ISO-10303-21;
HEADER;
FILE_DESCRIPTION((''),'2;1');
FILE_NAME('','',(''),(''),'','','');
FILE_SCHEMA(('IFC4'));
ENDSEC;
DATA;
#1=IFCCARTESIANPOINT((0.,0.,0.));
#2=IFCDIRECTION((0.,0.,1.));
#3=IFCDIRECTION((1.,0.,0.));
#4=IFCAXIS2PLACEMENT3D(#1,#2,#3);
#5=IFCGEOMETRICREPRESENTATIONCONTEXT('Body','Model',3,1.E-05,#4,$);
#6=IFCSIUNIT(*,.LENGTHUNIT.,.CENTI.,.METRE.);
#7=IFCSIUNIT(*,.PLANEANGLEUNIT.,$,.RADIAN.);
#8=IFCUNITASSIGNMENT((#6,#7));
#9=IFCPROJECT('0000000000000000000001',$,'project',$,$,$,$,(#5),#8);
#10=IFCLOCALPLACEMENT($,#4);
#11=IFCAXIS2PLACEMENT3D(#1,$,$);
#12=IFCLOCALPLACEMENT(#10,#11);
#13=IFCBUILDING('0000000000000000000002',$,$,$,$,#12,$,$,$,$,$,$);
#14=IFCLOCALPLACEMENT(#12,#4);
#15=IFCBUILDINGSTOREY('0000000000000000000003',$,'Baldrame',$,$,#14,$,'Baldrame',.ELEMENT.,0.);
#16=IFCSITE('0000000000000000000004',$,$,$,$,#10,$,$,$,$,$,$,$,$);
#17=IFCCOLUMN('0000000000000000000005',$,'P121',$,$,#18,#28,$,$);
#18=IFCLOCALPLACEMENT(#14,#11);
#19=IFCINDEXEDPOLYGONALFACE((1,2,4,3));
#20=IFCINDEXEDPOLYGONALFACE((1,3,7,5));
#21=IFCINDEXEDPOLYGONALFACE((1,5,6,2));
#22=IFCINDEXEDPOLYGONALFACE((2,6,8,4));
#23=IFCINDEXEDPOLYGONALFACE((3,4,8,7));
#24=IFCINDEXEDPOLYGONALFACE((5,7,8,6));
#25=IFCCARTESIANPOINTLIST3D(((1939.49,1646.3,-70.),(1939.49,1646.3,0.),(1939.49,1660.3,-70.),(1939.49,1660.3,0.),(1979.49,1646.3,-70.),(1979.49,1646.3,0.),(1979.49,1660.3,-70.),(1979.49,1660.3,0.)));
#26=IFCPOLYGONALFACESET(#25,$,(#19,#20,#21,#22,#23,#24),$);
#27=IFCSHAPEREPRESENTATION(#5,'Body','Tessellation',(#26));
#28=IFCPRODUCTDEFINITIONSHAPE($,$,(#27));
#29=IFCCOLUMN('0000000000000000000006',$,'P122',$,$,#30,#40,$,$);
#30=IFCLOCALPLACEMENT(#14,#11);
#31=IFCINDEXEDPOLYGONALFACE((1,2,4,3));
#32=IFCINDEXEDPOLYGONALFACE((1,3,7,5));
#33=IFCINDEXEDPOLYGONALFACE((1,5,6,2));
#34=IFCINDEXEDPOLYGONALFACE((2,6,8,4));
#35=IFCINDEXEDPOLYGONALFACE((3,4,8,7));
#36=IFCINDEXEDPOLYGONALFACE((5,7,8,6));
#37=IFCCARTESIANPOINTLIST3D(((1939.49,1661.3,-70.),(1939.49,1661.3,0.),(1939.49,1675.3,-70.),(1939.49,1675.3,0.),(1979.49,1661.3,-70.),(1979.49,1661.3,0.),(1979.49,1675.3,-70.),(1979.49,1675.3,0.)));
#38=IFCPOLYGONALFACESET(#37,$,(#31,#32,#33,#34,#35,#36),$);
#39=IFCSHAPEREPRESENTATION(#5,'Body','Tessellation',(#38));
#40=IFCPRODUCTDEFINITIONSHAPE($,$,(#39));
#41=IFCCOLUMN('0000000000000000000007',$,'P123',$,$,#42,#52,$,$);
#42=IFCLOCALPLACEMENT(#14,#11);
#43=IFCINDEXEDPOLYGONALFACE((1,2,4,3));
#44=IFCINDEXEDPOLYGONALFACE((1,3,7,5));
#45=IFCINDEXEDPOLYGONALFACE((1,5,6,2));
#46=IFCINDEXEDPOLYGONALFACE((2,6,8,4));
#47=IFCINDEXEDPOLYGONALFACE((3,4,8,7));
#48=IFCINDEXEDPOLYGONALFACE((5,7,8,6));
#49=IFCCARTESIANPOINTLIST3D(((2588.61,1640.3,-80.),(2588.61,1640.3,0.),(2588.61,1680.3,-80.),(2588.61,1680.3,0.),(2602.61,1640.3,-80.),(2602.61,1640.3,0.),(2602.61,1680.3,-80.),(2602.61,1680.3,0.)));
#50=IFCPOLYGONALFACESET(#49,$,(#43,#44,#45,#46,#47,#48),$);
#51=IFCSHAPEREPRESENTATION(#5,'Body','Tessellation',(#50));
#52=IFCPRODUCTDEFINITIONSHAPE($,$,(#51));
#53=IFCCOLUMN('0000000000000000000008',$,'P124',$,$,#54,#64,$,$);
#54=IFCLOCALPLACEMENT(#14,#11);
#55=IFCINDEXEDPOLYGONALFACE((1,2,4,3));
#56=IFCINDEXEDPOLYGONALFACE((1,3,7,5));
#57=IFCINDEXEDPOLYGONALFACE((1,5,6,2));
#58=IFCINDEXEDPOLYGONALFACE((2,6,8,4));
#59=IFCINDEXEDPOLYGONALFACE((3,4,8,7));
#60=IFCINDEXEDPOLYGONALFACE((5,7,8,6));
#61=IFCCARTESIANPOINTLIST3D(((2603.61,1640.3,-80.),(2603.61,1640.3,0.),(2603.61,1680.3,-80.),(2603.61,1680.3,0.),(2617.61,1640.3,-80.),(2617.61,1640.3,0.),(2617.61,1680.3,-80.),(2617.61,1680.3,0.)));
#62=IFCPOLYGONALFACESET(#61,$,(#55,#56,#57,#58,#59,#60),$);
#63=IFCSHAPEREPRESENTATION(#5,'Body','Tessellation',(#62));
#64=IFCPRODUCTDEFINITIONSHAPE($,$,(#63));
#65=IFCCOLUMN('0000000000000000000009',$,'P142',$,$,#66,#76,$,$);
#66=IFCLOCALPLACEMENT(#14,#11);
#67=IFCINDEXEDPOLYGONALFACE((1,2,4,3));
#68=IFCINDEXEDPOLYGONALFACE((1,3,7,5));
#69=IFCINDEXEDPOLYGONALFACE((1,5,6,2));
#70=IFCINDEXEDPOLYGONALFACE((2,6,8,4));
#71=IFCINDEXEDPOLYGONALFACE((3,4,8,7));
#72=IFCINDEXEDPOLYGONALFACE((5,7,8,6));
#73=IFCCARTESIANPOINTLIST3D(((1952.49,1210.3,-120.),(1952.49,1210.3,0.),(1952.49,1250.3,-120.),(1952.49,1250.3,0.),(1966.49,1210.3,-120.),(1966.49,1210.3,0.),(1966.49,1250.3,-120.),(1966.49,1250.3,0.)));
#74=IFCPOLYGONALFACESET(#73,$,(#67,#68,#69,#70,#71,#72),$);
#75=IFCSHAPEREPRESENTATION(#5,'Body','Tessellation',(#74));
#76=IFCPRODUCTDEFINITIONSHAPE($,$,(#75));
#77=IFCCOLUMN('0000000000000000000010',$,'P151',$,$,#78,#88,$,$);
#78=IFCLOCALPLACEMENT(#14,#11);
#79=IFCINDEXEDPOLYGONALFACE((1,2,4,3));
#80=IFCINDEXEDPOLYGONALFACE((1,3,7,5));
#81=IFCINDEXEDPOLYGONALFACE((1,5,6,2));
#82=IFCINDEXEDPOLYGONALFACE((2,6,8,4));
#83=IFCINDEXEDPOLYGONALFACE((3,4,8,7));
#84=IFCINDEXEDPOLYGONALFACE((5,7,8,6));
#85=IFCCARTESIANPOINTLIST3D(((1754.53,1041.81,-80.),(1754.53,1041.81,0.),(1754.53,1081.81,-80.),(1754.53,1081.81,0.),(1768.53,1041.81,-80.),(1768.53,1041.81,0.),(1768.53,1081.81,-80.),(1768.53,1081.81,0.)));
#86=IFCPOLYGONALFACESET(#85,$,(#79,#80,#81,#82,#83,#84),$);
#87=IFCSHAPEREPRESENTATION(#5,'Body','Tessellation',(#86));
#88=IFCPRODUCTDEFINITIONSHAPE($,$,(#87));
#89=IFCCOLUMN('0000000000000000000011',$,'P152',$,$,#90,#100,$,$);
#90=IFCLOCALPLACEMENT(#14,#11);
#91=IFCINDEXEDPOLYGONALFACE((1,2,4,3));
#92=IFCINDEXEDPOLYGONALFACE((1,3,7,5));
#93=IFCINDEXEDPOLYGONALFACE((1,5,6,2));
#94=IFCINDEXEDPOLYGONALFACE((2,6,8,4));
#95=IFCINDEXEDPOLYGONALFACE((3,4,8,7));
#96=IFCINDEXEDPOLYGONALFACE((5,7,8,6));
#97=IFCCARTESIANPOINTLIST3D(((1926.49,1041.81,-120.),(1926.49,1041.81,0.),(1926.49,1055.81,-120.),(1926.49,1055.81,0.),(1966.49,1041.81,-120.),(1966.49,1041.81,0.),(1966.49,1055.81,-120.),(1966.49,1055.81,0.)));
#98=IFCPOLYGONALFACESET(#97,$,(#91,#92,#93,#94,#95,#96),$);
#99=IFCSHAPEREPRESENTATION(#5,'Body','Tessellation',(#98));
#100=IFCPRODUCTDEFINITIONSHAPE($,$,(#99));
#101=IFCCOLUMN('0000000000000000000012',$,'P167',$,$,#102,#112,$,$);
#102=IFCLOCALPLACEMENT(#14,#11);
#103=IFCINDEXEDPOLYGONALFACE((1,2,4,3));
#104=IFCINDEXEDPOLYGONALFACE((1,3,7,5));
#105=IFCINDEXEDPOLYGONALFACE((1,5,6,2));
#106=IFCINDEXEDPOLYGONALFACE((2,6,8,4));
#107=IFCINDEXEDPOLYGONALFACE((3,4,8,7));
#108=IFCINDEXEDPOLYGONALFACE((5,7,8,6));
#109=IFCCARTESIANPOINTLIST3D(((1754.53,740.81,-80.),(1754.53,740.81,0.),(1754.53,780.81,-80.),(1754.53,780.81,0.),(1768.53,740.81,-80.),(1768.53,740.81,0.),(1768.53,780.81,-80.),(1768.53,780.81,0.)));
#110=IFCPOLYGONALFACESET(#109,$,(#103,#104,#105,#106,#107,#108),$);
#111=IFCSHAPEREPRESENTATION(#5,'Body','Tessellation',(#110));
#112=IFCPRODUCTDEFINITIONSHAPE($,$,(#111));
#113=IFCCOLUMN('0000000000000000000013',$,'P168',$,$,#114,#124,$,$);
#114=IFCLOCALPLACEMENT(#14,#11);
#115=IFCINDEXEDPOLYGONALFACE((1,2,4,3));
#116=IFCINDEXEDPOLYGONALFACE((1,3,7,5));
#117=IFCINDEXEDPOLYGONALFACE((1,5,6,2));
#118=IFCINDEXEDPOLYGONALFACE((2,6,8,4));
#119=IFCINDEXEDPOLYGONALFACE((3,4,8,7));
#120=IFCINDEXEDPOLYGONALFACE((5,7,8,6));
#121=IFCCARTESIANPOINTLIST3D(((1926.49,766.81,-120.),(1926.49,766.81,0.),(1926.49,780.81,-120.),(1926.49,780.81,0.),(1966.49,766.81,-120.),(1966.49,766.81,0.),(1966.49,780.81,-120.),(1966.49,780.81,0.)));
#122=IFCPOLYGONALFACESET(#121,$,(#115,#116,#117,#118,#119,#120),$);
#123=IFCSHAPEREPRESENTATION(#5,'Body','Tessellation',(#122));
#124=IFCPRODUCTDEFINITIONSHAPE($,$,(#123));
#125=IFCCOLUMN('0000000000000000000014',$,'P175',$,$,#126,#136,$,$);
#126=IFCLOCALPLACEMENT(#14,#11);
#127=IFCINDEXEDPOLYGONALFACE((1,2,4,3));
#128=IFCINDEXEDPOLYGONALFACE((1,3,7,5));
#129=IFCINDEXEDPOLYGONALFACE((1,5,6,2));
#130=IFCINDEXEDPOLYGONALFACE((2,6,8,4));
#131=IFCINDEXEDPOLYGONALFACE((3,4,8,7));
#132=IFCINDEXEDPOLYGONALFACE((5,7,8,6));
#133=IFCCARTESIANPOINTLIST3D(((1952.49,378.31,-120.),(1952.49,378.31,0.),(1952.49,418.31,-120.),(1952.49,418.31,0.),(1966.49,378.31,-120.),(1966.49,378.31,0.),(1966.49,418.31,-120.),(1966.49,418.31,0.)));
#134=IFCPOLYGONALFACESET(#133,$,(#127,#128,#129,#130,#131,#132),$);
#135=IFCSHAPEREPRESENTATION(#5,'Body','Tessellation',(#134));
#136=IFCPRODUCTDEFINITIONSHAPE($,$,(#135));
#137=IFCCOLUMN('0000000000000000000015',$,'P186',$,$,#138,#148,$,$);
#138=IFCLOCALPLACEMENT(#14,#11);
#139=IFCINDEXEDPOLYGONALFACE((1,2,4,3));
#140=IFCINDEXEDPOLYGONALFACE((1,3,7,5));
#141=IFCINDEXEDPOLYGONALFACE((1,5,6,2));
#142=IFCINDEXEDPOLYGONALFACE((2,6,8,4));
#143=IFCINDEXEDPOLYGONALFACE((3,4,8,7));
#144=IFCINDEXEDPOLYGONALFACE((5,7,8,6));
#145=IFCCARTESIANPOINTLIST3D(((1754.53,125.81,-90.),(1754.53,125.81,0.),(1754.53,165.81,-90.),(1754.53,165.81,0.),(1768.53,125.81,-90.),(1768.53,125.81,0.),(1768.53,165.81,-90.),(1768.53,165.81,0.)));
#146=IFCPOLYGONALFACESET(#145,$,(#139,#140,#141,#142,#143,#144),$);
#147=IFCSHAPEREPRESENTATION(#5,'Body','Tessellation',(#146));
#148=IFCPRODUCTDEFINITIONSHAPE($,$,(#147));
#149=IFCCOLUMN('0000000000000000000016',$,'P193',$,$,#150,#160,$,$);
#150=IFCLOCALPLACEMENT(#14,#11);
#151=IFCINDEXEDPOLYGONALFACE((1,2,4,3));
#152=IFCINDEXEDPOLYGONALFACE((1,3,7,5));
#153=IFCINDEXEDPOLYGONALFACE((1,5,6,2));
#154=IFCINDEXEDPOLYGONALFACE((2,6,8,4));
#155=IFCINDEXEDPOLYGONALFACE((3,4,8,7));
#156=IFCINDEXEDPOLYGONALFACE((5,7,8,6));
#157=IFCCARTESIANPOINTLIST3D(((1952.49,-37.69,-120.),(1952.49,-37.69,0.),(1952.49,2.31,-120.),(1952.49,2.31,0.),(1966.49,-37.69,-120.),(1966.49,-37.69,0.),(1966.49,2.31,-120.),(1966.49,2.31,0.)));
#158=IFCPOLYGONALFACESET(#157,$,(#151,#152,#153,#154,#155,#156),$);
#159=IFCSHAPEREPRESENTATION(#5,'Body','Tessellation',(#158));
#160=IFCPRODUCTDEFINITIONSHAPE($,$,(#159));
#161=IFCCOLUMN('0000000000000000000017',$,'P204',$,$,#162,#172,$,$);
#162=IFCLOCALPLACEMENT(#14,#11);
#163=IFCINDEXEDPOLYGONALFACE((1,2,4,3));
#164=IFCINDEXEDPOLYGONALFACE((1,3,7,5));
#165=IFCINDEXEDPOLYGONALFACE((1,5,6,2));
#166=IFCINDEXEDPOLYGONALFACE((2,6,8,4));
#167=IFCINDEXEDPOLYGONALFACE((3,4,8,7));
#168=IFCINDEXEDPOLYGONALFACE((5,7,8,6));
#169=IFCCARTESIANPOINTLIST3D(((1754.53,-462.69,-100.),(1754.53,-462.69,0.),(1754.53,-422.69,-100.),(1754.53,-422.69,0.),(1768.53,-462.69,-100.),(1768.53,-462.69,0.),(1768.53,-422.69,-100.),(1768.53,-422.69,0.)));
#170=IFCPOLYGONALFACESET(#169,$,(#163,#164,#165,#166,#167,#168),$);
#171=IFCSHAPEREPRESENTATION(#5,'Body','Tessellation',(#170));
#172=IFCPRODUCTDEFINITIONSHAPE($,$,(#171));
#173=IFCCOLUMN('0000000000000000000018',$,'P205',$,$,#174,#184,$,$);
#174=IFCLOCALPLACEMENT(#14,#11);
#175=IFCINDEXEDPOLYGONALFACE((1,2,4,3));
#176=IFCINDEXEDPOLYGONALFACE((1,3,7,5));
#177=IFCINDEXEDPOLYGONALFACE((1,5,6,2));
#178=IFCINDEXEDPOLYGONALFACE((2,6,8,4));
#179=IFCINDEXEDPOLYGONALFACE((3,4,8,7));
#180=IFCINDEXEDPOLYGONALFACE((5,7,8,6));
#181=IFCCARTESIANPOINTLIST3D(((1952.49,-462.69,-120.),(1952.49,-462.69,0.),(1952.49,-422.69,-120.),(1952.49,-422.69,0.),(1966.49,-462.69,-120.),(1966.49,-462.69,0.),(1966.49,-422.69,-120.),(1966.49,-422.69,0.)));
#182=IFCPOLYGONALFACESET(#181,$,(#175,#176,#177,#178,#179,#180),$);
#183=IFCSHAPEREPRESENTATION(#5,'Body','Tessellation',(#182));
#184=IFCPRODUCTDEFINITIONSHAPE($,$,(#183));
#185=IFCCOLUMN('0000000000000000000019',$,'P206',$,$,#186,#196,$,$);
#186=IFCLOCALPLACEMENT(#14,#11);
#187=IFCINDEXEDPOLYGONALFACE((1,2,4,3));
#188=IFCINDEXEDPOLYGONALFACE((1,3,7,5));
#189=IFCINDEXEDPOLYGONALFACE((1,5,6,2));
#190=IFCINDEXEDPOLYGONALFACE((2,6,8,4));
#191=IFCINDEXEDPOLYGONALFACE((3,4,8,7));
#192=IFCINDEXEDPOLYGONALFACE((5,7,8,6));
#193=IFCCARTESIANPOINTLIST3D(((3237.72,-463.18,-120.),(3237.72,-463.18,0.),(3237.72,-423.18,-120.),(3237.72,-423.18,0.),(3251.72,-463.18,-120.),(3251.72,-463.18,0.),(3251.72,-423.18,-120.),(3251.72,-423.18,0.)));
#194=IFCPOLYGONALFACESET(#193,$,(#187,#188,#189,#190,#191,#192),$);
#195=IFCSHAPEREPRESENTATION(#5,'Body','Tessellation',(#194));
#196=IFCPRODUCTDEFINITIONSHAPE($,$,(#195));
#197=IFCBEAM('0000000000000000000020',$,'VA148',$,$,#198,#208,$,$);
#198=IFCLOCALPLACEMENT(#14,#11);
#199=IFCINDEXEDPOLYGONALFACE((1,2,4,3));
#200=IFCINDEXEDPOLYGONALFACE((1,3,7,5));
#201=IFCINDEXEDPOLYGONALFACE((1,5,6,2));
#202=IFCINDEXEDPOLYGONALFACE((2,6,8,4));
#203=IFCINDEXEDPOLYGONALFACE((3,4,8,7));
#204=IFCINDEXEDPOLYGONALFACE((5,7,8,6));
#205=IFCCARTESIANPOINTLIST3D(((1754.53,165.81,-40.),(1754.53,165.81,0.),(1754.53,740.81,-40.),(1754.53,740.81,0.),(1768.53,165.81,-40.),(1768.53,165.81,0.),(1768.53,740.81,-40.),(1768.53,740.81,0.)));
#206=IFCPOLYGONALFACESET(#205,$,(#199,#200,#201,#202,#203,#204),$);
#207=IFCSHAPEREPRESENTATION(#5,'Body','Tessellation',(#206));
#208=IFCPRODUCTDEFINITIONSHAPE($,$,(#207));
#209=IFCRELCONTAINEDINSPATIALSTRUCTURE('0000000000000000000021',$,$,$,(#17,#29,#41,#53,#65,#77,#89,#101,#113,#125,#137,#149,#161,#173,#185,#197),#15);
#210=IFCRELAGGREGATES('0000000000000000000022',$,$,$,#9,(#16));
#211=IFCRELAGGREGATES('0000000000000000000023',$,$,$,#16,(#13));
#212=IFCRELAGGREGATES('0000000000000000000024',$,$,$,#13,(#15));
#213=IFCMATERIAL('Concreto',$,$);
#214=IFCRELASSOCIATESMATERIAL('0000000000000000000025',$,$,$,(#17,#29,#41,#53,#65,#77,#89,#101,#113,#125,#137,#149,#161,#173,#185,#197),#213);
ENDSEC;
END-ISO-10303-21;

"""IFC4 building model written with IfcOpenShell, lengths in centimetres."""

from ifc_helpers import new_model, si_unit, frame, origin, origin_with_axes, origin_2d_with_axis, place, context, project, spatial, rectangle, extrude, material, element, save


model = new_model("IFC4")

# Units and contexts
model_context = context("Model", 3, precision=1e-05, world=origin_with_axes(), identifier="Body")
ifc_project = project(units=[si_unit("LENGTHUNIT", "METRE", prefix="CENTI"), si_unit("PLANEANGLEUNIT", "RADIAN")], contexts=[model_context])

# Site, building, storey
site_placement = place(None, origin_with_axes())
site = spatial("IfcSite", under=ifc_project, at=site_placement)
building_placement = place(site_placement, origin())
building = spatial("IfcBuilding", under=site, at=building_placement)
storey_placement = place(building_placement, origin_with_axes())
storey = spatial("IfcBuildingStorey", under=building, at=storey_placement, Name="Baldrame", LongName="Baldrame", CompositionType="ELEMENT", Elevation=0.0)

# Columns
ifc_material = material(Name="Concreto")
for number, where, z_axis, x_axis, name in (
    (1, (1959.49, 1653.3, 0.0), (0.0, 0.0, 1.0), (1.0, 0.0, 0.0), "P121"),
    (2, (1959.49, 1668.3, 0.0), (0.0, 0.0, 1.0), (1.0, 0.0, 0.0), "P122"),
):
    element("IfcColumn", number, at=place(storey_placement, frame(where, z_axis=z_axis, x_axis=x_axis)), inside=storey, material=ifc_material, Name=name, context=model_context, shape_type="SolidModel", body=[
        extrude(rectangle(XDim=14.0, YDim=40.0, at=origin_2d_with_axis()), frame((0.0, 0.0, -70.0), z_axis=(0.0, 0.0, 1.0), x_axis=(0.0, -1.0, 0.0)), (0.0, 0.0, 1.0), 70.0),
    ])
for number, where, z_axis, x_axis, name in (
    (3, (2595.61, 1660.3, 0.0), (0.0, 0.0, 1.0), (1.0, 0.0, 0.0), "P123"),
    (4, (2610.61, 1660.3, 0.0), (0.0, 0.0, 1.0), (1.0, 0.0, 0.0), "P124"),
):
    element("IfcColumn", number, at=place(storey_placement, frame(where, z_axis=z_axis, x_axis=x_axis)), inside=storey, material=ifc_material, Name=name, context=model_context, shape_type="SolidModel", body=[
        extrude(rectangle(XDim=14.0, YDim=40.0, at=origin_2d_with_axis()), frame((0.0, 0.0, -80.0), z_axis=(0.0, 0.0, 1.0), x_axis=(1.0, 0.0, 0.0)), (0.0, 0.0, 1.0), 80.0),
    ])
column_1_placement = place(storey_placement, frame((1959.49, 1230.3, 0.0), z_axis=(0.0, 0.0, 1.0), x_axis=(1.0, 0.0, 0.0)))
element("IfcColumn", 5, at=column_1_placement, inside=storey, material=ifc_material, Name="P142", context=model_context, shape_type="SolidModel", body=[
    extrude(rectangle(XDim=14.0, YDim=40.0, at=origin_2d_with_axis()), frame((0.0, 0.0, -120.0), z_axis=(0.0, 0.0, 1.0), x_axis=(1.0, 0.0, 0.0)), (0.0, 0.0, 1.0), 120.0),
])
column_2_placement = place(storey_placement, frame((1761.53, 1061.81, 0.0), z_axis=(0.0, 0.0, 1.0), x_axis=(1.0, 0.0, 0.0)))
element("IfcColumn", 6, at=column_2_placement, inside=storey, material=ifc_material, Name="P151", context=model_context, shape_type="SolidModel", body=[
    extrude(rectangle(XDim=14.0, YDim=40.0, at=origin_2d_with_axis()), frame((0.0, 0.0, -80.0), z_axis=(0.0, 0.0, 1.0), x_axis=(1.0, 0.0, 0.0)), (0.0, 0.0, 1.0), 80.0),
])
column_3_placement = place(storey_placement, frame((1946.49, 1048.81, 0.0), z_axis=(0.0, 0.0, 1.0), x_axis=(1.0, 0.0, 0.0)))
element("IfcColumn", 7, at=column_3_placement, inside=storey, material=ifc_material, Name="P152", context=model_context, shape_type="SolidModel", body=[
    extrude(rectangle(XDim=14.0, YDim=40.0, at=origin_2d_with_axis()), frame((0.0, 0.0, -120.0), z_axis=(0.0, 0.0, 1.0), x_axis=(0.0, -1.0, 0.0)), (0.0, 0.0, 1.0), 120.0),
])
column_4_placement = place(storey_placement, frame((1761.53, 760.81, 0.0), z_axis=(0.0, 0.0, 1.0), x_axis=(1.0, 0.0, 0.0)))
element("IfcColumn", 8, at=column_4_placement, inside=storey, material=ifc_material, Name="P167", context=model_context, shape_type="SolidModel", body=[
    extrude(rectangle(XDim=14.0, YDim=40.0, at=origin_2d_with_axis()), frame((0.0, 0.0, -80.0), z_axis=(0.0, 0.0, 1.0), x_axis=(1.0, 0.0, 0.0)), (0.0, 0.0, 1.0), 80.0),
])
column_5_placement = place(storey_placement, frame((1946.49, 773.81, 0.0), z_axis=(0.0, 0.0, 1.0), x_axis=(1.0, 0.0, 0.0)))
element("IfcColumn", 9, at=column_5_placement, inside=storey, material=ifc_material, Name="P168", context=model_context, shape_type="SolidModel", body=[
    extrude(rectangle(XDim=14.0, YDim=40.0, at=origin_2d_with_axis()), frame((0.0, 0.0, -120.0), z_axis=(0.0, 0.0, 1.0), x_axis=(0.0, -1.0, 0.0)), (0.0, 0.0, 1.0), 120.0),
])
column_6_placement = place(storey_placement, frame((1959.49, 398.31, 0.0), z_axis=(0.0, 0.0, 1.0), x_axis=(1.0, 0.0, 0.0)))
element("IfcColumn", 10, at=column_6_placement, inside=storey, material=ifc_material, Name="P175", context=model_context, shape_type="SolidModel", body=[
    extrude(rectangle(XDim=14.0, YDim=40.0, at=origin_2d_with_axis()), frame((0.0, 0.0, -120.0), z_axis=(0.0, 0.0, 1.0), x_axis=(1.0, 0.0, 0.0)), (0.0, 0.0, 1.0), 120.0),
])
column_7_placement = place(storey_placement, frame((1761.53, 145.81, 0.0), z_axis=(0.0, 0.0, 1.0), x_axis=(1.0, 0.0, 0.0)))
element("IfcColumn", 11, at=column_7_placement, inside=storey, material=ifc_material, Name="P186", context=model_context, shape_type="SolidModel", body=[
    extrude(rectangle(XDim=14.0, YDim=40.0, at=origin_2d_with_axis()), frame((0.0, 0.0, -90.0), z_axis=(0.0, 0.0, 1.0), x_axis=(1.0, 0.0, 0.0)), (0.0, 0.0, 1.0), 90.0),
])
column_8_placement = place(storey_placement, frame((1959.49, -17.69, 0.0), z_axis=(0.0, 0.0, 1.0), x_axis=(1.0, 0.0, 0.0)))
element("IfcColumn", 12, at=column_8_placement, inside=storey, material=ifc_material, Name="P193", context=model_context, shape_type="SolidModel", body=[
    extrude(rectangle(XDim=14.0, YDim=40.0, at=origin_2d_with_axis()), frame((0.0, 0.0, -120.0), z_axis=(0.0, 0.0, 1.0), x_axis=(1.0, 0.0, 0.0)), (0.0, 0.0, 1.0), 120.0),
])
column_9_placement = place(storey_placement, frame((1761.53, -442.69, 0.0), z_axis=(0.0, 0.0, 1.0), x_axis=(1.0, 0.0, 0.0)))
element("IfcColumn", 13, at=column_9_placement, inside=storey, material=ifc_material, Name="P204", context=model_context, shape_type="SolidModel", body=[
    extrude(rectangle(XDim=14.0, YDim=40.0, at=origin_2d_with_axis()), frame((0.0, 0.0, -100.0), z_axis=(0.0, 0.0, 1.0), x_axis=(1.0, 0.0, 0.0)), (0.0, 0.0, 1.0), 100.0),
])
for number, where, z_axis, x_axis, name in (
    (14, (1959.49, -442.69, 0.0), (0.0, 0.0, 1.0), (1.0, 0.0, 0.0), "P205"),
    (15, (3244.72, -443.18, 0.0), (0.0, 0.0, 1.0), (1.0, 0.0, 0.0), "P206"),
):
    element("IfcColumn", number, at=place(storey_placement, frame(where, z_axis=z_axis, x_axis=x_axis)), inside=storey, material=ifc_material, Name=name, context=model_context, shape_type="SolidModel", body=[
        extrude(rectangle(XDim=14.0, YDim=40.0, at=origin_2d_with_axis()), frame((0.0, 0.0, -120.0), z_axis=(0.0, 0.0, 1.0), x_axis=(1.0, 0.0, 0.0)), (0.0, 0.0, 1.0), 120.0),
    ])

# Beam
beam_1_placement = place(storey_placement, frame((1761.53, 453.31, 0.0), z_axis=(0.0, 0.0, 1.0), x_axis=(1.0, 0.0, 0.0)))
element("IfcBeam", 16, at=beam_1_placement, inside=storey, material=ifc_material, Name="VA148", context=model_context, shape_type="SolidModel", body=[
    extrude(rectangle(XDim=14.0, YDim=40.0, at=origin_2d_with_axis()), frame((0.0, -287.5, -20.0), z_axis=(0.0, 1.0, 0.0), x_axis=(1.0, 0.0, 0.0)), (0.0, 0.0, 1.0), 575.0),
])

save(model, "model.ifc")
